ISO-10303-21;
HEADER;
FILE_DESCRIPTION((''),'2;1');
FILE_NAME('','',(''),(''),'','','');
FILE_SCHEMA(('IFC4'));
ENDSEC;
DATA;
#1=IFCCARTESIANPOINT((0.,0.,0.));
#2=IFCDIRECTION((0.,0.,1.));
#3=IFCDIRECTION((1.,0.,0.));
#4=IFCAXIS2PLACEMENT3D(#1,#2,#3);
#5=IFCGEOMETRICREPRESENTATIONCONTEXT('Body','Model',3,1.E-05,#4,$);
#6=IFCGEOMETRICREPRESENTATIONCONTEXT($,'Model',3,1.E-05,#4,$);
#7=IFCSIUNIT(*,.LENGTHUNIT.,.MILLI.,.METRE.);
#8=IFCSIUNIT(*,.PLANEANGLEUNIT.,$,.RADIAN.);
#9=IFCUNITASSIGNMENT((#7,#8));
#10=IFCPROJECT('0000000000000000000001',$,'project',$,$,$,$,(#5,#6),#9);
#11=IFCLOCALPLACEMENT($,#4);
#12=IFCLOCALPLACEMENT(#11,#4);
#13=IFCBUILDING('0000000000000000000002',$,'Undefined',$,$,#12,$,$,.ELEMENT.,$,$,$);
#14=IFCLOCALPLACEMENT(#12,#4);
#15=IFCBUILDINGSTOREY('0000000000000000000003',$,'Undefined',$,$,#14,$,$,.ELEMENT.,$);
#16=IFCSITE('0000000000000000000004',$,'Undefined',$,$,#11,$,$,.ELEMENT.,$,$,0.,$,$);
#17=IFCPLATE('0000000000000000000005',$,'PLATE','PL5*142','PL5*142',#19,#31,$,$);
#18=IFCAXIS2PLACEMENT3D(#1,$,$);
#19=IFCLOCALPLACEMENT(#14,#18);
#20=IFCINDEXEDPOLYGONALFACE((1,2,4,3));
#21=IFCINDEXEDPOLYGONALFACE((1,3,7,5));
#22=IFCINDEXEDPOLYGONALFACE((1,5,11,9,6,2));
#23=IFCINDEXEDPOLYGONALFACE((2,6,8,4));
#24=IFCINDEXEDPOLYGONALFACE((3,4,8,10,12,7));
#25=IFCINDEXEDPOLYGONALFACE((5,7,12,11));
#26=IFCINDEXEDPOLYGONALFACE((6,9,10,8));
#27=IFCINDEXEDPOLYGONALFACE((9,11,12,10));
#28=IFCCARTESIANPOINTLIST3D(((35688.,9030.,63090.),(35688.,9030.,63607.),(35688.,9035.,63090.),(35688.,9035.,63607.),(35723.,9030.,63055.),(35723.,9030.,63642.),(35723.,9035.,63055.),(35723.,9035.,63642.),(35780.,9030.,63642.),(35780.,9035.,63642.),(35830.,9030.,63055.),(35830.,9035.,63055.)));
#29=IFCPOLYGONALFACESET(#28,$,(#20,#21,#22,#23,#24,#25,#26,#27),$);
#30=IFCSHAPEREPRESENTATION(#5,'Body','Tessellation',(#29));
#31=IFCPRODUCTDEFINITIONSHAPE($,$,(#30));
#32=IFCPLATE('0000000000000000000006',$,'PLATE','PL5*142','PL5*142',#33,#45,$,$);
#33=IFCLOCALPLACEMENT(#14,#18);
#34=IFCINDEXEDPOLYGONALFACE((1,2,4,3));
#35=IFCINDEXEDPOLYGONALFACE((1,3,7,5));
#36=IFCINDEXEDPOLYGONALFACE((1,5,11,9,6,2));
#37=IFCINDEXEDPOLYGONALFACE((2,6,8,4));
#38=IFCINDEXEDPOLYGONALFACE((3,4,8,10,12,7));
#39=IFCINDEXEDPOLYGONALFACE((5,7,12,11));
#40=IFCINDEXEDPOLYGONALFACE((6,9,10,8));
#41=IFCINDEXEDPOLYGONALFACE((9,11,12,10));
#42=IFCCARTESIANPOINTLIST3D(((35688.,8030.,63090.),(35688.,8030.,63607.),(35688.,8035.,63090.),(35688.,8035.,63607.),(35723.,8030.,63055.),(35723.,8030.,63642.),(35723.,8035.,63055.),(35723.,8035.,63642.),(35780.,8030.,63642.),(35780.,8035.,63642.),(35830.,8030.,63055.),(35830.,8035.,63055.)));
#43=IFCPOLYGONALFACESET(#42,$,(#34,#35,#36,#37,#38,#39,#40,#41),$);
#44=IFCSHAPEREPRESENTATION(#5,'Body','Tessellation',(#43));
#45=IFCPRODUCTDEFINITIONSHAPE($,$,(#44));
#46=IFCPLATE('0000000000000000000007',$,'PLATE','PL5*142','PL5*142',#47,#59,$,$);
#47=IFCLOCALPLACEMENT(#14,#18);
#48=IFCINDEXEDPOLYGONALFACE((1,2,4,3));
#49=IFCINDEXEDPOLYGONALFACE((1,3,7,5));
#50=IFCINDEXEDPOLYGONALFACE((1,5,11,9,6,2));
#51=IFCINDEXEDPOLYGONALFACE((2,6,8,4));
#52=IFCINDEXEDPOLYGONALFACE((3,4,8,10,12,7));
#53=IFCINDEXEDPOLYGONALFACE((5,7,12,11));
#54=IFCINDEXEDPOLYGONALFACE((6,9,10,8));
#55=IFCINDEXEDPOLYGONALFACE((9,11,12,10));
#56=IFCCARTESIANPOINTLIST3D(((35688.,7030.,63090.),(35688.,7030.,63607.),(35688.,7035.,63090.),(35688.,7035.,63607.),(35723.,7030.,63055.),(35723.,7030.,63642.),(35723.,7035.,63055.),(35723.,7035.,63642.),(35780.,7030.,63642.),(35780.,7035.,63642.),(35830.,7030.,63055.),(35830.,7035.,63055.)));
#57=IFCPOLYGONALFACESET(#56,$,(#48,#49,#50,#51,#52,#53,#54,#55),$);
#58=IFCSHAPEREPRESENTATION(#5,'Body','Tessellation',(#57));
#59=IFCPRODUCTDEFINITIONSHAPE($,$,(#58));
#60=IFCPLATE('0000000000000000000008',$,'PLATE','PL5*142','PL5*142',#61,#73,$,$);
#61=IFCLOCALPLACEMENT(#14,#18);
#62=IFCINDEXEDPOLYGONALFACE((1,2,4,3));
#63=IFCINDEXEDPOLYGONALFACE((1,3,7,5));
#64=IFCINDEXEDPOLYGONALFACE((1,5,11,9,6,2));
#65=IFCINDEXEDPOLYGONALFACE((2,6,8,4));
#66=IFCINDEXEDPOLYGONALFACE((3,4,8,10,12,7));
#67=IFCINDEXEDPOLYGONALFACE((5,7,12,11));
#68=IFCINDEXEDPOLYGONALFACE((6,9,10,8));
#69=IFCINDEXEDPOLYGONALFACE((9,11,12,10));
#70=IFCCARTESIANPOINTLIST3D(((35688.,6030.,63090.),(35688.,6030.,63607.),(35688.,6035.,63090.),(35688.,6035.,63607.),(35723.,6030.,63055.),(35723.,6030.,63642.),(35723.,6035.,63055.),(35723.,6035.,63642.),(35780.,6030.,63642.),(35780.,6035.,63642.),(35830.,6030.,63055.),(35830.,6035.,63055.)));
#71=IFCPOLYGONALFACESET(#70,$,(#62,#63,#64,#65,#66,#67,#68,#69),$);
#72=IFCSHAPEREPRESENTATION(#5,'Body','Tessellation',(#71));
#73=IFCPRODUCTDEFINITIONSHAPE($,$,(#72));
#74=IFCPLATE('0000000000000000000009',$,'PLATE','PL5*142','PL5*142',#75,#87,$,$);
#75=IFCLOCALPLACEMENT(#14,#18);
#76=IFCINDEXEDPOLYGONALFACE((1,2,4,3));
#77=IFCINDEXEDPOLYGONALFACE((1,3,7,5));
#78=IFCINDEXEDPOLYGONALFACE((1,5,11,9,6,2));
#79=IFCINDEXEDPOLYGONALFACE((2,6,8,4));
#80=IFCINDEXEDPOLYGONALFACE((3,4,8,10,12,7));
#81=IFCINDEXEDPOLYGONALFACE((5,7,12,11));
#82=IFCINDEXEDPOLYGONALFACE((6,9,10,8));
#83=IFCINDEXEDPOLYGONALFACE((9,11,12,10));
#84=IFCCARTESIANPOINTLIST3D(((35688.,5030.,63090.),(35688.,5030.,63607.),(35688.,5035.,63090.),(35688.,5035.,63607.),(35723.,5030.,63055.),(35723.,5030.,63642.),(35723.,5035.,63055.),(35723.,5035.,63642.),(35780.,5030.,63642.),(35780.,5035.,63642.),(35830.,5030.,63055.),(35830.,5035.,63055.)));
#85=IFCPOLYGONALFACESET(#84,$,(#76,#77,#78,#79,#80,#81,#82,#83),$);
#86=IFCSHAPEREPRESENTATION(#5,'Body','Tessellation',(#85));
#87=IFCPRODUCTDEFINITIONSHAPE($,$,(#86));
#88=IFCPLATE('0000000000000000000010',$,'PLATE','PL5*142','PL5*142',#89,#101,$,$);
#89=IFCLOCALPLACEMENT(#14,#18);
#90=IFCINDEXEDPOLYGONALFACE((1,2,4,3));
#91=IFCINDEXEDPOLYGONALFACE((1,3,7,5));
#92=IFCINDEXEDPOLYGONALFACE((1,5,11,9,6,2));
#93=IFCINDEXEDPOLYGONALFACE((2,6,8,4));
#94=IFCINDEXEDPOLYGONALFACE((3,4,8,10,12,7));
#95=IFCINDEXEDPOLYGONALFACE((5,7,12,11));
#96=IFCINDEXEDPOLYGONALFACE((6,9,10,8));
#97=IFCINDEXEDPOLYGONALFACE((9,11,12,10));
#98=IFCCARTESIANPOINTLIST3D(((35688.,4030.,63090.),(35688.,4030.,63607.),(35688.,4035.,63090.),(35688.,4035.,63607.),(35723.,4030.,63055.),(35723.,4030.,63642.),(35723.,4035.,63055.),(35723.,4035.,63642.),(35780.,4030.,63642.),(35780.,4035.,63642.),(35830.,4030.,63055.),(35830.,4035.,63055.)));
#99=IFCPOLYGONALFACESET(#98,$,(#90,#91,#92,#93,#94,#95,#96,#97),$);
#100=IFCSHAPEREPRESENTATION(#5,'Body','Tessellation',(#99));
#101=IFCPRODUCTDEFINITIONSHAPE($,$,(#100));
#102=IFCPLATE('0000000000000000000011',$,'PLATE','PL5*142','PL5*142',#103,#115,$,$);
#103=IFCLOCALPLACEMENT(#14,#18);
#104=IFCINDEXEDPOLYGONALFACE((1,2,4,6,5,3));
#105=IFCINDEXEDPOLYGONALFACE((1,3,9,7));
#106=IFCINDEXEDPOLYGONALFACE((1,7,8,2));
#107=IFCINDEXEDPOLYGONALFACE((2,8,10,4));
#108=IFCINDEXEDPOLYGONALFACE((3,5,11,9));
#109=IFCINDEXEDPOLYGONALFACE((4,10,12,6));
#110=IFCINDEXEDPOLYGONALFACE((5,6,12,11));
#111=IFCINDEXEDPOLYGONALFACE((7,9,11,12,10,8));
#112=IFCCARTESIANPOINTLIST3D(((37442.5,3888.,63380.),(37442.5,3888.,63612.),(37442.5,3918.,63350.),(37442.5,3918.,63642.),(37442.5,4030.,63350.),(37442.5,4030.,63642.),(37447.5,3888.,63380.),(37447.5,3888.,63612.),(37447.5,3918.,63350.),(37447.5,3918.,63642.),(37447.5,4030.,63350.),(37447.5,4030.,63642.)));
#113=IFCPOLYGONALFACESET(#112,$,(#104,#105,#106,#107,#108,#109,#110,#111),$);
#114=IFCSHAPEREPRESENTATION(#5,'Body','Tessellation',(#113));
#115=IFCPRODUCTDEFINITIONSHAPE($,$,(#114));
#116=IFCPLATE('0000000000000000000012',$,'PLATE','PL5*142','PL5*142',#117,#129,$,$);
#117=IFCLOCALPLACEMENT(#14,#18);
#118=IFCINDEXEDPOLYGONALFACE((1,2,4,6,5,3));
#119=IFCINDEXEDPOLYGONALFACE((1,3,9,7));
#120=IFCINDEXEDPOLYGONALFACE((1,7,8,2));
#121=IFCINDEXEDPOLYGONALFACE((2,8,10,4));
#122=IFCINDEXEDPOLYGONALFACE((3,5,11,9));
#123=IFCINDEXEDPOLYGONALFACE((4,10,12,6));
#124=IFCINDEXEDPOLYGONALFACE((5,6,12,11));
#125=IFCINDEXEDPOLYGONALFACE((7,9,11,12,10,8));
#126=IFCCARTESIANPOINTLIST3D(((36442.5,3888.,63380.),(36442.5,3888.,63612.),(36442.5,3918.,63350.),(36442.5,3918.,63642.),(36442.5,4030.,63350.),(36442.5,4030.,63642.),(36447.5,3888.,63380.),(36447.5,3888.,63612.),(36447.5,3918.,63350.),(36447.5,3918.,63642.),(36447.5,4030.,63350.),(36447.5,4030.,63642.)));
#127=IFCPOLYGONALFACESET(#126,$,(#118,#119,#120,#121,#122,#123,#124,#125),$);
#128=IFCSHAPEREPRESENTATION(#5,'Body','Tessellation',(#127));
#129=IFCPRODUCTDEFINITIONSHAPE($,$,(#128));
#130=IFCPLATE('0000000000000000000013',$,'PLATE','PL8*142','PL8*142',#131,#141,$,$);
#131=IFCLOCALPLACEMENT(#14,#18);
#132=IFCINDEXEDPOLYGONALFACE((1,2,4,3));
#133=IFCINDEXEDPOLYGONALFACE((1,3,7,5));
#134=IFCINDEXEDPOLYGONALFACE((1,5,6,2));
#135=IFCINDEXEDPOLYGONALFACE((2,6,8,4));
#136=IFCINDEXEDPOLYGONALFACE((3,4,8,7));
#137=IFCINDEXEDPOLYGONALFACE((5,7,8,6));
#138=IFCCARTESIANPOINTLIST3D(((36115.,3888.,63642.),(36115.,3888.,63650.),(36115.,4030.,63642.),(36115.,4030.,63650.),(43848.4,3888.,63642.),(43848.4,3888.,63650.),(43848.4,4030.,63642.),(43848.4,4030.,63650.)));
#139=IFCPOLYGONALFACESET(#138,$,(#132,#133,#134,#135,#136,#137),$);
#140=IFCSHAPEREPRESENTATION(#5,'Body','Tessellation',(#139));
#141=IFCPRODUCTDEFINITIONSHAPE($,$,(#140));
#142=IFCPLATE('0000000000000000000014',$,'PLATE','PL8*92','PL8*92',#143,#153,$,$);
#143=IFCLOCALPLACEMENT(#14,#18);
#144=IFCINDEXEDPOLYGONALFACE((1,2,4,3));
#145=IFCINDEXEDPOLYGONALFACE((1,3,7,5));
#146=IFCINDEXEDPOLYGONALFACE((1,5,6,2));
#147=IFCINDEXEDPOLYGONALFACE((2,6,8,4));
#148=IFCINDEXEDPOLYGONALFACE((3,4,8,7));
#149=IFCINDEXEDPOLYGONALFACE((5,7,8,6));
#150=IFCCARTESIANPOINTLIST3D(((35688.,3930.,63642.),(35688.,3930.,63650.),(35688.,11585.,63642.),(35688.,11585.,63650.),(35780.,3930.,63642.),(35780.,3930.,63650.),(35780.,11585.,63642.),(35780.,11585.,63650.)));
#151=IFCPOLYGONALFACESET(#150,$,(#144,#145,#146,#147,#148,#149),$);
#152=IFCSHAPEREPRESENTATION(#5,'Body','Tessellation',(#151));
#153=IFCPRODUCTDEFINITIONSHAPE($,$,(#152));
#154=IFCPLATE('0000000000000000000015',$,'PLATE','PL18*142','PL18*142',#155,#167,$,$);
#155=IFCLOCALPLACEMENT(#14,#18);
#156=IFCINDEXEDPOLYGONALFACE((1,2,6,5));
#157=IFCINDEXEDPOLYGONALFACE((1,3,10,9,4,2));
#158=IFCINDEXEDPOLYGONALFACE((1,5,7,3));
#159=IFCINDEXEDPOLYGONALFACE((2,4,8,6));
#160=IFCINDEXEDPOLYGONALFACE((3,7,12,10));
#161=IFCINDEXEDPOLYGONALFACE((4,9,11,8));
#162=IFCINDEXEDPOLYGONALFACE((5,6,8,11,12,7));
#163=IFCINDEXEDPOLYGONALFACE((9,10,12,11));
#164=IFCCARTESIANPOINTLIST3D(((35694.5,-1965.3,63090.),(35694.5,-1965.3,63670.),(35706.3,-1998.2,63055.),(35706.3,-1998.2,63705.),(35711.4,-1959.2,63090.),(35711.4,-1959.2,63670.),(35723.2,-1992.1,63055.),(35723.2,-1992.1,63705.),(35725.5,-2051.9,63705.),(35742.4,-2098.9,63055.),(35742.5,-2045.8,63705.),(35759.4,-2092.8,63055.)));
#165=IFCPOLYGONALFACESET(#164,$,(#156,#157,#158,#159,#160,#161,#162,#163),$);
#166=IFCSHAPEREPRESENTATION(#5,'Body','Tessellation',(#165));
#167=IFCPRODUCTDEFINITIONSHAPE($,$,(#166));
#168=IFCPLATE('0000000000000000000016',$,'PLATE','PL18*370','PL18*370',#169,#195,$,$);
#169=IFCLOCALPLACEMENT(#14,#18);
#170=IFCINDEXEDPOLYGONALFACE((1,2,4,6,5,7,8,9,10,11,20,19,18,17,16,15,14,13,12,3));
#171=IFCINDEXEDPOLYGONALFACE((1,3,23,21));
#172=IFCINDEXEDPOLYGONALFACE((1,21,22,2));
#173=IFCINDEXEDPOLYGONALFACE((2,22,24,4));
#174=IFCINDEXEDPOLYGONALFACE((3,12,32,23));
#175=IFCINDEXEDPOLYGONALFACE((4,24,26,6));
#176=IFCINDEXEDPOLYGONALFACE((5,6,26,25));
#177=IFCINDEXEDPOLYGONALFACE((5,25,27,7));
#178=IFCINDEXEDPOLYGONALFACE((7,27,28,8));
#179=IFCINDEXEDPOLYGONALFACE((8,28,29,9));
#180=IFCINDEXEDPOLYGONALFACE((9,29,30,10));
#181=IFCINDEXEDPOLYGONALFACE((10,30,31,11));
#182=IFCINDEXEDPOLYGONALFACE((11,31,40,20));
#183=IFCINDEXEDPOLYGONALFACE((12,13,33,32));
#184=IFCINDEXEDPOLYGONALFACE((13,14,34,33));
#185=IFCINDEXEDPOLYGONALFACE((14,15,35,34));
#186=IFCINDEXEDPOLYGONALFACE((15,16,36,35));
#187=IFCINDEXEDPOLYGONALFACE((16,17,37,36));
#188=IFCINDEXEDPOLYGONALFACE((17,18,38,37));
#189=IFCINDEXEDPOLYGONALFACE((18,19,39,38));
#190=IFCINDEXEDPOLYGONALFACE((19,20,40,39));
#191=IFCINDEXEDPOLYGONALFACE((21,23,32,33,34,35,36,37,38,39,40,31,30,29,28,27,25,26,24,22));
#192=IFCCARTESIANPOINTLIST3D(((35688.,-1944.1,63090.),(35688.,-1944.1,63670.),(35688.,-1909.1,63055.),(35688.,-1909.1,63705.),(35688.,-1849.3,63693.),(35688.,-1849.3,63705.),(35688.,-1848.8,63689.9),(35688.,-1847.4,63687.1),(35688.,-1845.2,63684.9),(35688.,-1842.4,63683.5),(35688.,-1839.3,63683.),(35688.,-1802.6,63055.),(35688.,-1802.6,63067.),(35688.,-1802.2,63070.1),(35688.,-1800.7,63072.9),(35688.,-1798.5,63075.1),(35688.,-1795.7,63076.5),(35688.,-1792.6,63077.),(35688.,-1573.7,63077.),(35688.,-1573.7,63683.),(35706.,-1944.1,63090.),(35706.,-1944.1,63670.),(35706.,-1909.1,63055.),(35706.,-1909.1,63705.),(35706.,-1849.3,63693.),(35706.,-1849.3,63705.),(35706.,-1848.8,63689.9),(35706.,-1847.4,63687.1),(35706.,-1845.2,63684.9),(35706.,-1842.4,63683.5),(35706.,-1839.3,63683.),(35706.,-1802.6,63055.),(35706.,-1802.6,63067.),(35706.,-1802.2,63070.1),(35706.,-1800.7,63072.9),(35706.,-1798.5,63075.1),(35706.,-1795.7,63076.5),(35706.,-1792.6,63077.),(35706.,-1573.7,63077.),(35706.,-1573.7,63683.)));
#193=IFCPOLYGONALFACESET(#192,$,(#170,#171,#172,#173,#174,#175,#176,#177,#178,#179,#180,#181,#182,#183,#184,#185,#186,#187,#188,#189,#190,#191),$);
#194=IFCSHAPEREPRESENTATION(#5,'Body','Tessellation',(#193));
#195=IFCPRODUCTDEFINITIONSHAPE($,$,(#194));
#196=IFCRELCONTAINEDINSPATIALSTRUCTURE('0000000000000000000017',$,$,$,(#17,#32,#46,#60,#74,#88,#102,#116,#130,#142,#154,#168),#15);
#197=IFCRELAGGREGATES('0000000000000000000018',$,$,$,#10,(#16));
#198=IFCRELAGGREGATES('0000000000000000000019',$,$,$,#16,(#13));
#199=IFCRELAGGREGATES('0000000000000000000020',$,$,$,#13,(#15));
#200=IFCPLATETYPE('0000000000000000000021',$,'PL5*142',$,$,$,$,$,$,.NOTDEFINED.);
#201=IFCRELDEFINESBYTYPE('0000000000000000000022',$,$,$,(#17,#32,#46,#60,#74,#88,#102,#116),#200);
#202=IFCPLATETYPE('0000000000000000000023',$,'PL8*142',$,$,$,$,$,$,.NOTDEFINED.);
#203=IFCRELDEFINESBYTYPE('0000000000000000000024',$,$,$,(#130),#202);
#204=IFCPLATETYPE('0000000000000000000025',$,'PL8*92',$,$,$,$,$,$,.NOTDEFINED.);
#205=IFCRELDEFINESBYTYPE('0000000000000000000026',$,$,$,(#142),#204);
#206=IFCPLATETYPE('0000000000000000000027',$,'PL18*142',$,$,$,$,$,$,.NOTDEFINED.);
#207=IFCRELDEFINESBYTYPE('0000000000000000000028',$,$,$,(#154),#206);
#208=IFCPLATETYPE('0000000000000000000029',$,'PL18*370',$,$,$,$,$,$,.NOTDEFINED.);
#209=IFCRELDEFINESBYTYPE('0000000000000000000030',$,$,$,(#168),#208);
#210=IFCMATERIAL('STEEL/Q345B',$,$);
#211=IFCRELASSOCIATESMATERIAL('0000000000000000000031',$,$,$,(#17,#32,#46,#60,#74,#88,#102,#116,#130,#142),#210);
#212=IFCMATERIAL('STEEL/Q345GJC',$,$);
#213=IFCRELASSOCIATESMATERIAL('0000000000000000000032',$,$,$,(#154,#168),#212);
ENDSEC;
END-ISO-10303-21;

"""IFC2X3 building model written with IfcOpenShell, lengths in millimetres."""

from ifc_helpers import new_model, si_unit, frame, origin_with_axes, place, context, project, spatial, polyline, outline, extrude, material, type_object, element, save


model = new_model("IFC2X3")

# Units and contexts
model_context_1 = context("Model", 3, precision=1e-05, world=origin_with_axes(), identifier="Body")
model_context_2 = context("Model", 3, precision=1e-05, world=origin_with_axes())
ifc_project = project(units=[si_unit("LENGTHUNIT", "METRE", prefix="MILLI"), si_unit("PLANEANGLEUNIT", "RADIAN")], contexts=[model_context_1, model_context_2])

# Site, building, storey
site_placement = place(None, origin_with_axes())
site = spatial("IfcSite", under=ifc_project, at=site_placement, Name="Undefined", CompositionType="ELEMENT", RefElevation=0.0)
building_placement = place(site_placement, origin_with_axes())
building = spatial("IfcBuilding", under=site, at=building_placement, Name="Undefined", CompositionType="ELEMENT")
storey_placement = place(building_placement, origin_with_axes())
storey = spatial("IfcBuildingStorey", under=building, at=storey_placement, Name="Undefined", CompositionType="ELEMENT")

# Shared definitions
ifc_material_1 = material(Name="STEEL/Q345B")
ifc_material_2 = material(Name="STEEL/Q345GJC")

# Plates
plate_type_1 = type_object("IfcPlateType", Name="PL5*142", PredefinedType="NOTDEFINED")
for number, where, z_axis, x_axis, name in (
    (1, (35688.0, 9032.5, 63642.0), (0.0, 1.0, 0.0), (1.0, 0.0, 0.0), "PLATE"),
    (2, (35688.0, 8032.5, 63642.0), (0.0, 1.0, 0.0), (1.0, 0.0, 0.0), "PLATE"),
    (3, (35688.0, 7032.5, 63642.0), (0.0, 1.0, 0.0), (1.0, 0.0, 0.0), "PLATE"),
    (4, (35688.0, 6032.5, 63642.0), (0.0, 1.0, 0.0), (1.0, 0.0, 0.0), "PLATE"),
    (5, (35688.0, 5032.5, 63642.0), (0.0, 1.0, 0.0), (1.0, 0.0, 0.0), "PLATE"),
    (6, (35688.0, 4032.5, 63642.0), (0.0, 1.0, 0.0), (1.0, 0.0, 0.0), "PLATE"),
):
    element("IfcPlate", number, at=place(storey_placement, frame(where, z_axis=z_axis, x_axis=x_axis)), inside=storey, type_object=plate_type_1, material=ifc_material_1, Name=name, Description="PL5*142", ObjectType="PL5*142", context=model_context_1, shape_type="SweptSolid", body=[
        extrude(outline(polyline([(0.0, 35.0), (35.0, 0.0), (92.0, 0.0), (142.0, 587.0), (35.0, 587.0), (0.0, 552.0), (0.0, 35.0)])), frame((0.0, 0.0, -2.5), z_axis=(0.0, 0.0, 1.0), x_axis=(1.0, 0.0, 0.0)), (0.0, 0.0, 1.0), 5.0),
    ])
for number, where, z_axis, x_axis, name in (
    (7, (37445.0, 4030.0, 63642.0), (1.0, 0.0, 0.0), (0.0, -1.0, 0.0), "PLATE"),
    (8, (36445.0, 4030.0, 63642.0), (1.0, 0.0, 0.0), (0.0, -1.0, 0.0), "PLATE"),
):
    element("IfcPlate", number, at=place(storey_placement, frame(where, z_axis=z_axis, x_axis=x_axis)), inside=storey, type_object=plate_type_1, material=ifc_material_1, Name=name, Description="PL5*142", ObjectType="PL5*142", context=model_context_1, shape_type="SweptSolid", body=[
        extrude(outline(polyline([(0.0, 0.0), (112.0, 0.0), (142.0, 30.0), (142.0, 262.0), (112.0, 292.0), (0.0, 292.0), (0.0, 0.0)])), frame((0.0, 0.0, -2.5), z_axis=(0.0, 0.0, 1.0), x_axis=(1.0, 0.0, 0.0)), (0.0, 0.0, 1.0), 5.0),
    ])
plate_type_2 = type_object("IfcPlateType", Name="PL8*142", PredefinedType="NOTDEFINED")
plate_1_placement = place(storey_placement, frame((36115.0, 4030.0, 63646.0), z_axis=(0.0, 0.0, -1.0), x_axis=(1.0, 0.0, 0.0)))
element("IfcPlate", 9, at=plate_1_placement, inside=storey, type_object=plate_type_2, material=ifc_material_1, Name="PLATE", Description="PL8*142", ObjectType="PL8*142", context=model_context_1, shape_type="SweptSolid", body=[
    extrude(outline(polyline([(0.0, 0.0), (7733.4, 0.0), (7733.4, 142.0), (0.0, 142.0), (0.0, 0.0)])), frame((0.0, 0.0, -4.0), z_axis=(0.0, 0.0, 1.0), x_axis=(1.0, 0.0, 0.0)), (0.0, 0.0, 1.0), 8.0),
])
plate_type_3 = type_object("IfcPlateType", Name="PL8*92", PredefinedType="NOTDEFINED")
plate_2_placement = place(storey_placement, frame((35780.0, 11585.0, 63646.0), z_axis=(0.0, 0.0, -1.0), x_axis=(0.0, -1.0, 0.0)))
element("IfcPlate", 10, at=plate_2_placement, inside=storey, type_object=plate_type_3, material=ifc_material_1, Name="PLATE", Description="PL8*92", ObjectType="PL8*92", context=model_context_1, shape_type="SweptSolid", body=[
    extrude(outline(polyline([(0.0, 0.0), (7655.0, 0.0), (7655.0, 92.0), (0.0, 92.0), (0.0, 0.0)])), frame((0.0, 0.0, -4.0), z_axis=(0.0, 0.0, 1.0), x_axis=(1.0, 0.0, 0.0)), (0.0, 0.0, 1.0), 8.0),
])
plate_type_4 = type_object("IfcPlateType", Name="PL18*142", PredefinedType="NOTDEFINED")
plate_3_placement = place(storey_placement, frame((35702.9, -1962.2, 63705.0), z_axis=(0.941212, 0.337816, 0.0), x_axis=(0.337816, -0.941212, 0.0)))
element("IfcPlate", 11, at=plate_3_placement, inside=storey, type_object=plate_type_4, material=ifc_material_2, Name="PLATE", Description="PL18*142", ObjectType="PL18*142", context=model_context_1, shape_type="SweptSolid", body=[
    extrude(outline(polyline([(0.0, 35.0), (35.0, 0.0), (92.0, 0.0), (142.0, 650.0), (35.0, 650.0), (0.0, 615.0), (0.0, 35.0)])), frame((0.0, 0.0, -9.0), z_axis=(0.0, 0.0, 1.0), x_axis=(1.0, 0.0, 0.0)), (0.0, 0.0, 1.0), 18.0),
])
plate_type_5 = type_object("IfcPlateType", Name="PL18*370", PredefinedType="NOTDEFINED")
plate_4_placement = place(storey_placement, frame((35697.0, -1849.3, 63705.0), z_axis=(1.0, 0.0, 0.0), x_axis=(0.0, -1.0, 0.0)))
element("IfcPlate", 12, at=plate_4_placement, inside=storey, type_object=plate_type_5, material=ifc_material_2, Name="PLATE", Description="PL18*370", ObjectType="PL18*370", context=model_context_1, shape_type="SweptSolid", body=[
    extrude(outline(polyline([(0.0, 0.0), (59.8, 0.0), (94.8, 35.0), (94.8, 615.0), (59.8, 650.0), (-46.7, 650.0), (-46.7, 638.0), (-47.2, 634.9), (-48.6, 632.1), (-50.8, 629.9), (-53.6, 628.5), (-56.7, 628.0), (-275.6, 628.0), (-275.6, 22.0), (-10.0, 22.0), (-6.9, 21.5), (-4.1, 20.1), (-1.9, 17.9), (-0.5, 15.1), (0.0, 12.0), (0.0, 0.0)])), frame((0.0, 0.0, -9.0), z_axis=(0.0, 0.0, 1.0), x_axis=(1.0, 0.0, 0.0)), (0.0, 0.0, 1.0), 18.0),
])

save(model, "model.ifc")
